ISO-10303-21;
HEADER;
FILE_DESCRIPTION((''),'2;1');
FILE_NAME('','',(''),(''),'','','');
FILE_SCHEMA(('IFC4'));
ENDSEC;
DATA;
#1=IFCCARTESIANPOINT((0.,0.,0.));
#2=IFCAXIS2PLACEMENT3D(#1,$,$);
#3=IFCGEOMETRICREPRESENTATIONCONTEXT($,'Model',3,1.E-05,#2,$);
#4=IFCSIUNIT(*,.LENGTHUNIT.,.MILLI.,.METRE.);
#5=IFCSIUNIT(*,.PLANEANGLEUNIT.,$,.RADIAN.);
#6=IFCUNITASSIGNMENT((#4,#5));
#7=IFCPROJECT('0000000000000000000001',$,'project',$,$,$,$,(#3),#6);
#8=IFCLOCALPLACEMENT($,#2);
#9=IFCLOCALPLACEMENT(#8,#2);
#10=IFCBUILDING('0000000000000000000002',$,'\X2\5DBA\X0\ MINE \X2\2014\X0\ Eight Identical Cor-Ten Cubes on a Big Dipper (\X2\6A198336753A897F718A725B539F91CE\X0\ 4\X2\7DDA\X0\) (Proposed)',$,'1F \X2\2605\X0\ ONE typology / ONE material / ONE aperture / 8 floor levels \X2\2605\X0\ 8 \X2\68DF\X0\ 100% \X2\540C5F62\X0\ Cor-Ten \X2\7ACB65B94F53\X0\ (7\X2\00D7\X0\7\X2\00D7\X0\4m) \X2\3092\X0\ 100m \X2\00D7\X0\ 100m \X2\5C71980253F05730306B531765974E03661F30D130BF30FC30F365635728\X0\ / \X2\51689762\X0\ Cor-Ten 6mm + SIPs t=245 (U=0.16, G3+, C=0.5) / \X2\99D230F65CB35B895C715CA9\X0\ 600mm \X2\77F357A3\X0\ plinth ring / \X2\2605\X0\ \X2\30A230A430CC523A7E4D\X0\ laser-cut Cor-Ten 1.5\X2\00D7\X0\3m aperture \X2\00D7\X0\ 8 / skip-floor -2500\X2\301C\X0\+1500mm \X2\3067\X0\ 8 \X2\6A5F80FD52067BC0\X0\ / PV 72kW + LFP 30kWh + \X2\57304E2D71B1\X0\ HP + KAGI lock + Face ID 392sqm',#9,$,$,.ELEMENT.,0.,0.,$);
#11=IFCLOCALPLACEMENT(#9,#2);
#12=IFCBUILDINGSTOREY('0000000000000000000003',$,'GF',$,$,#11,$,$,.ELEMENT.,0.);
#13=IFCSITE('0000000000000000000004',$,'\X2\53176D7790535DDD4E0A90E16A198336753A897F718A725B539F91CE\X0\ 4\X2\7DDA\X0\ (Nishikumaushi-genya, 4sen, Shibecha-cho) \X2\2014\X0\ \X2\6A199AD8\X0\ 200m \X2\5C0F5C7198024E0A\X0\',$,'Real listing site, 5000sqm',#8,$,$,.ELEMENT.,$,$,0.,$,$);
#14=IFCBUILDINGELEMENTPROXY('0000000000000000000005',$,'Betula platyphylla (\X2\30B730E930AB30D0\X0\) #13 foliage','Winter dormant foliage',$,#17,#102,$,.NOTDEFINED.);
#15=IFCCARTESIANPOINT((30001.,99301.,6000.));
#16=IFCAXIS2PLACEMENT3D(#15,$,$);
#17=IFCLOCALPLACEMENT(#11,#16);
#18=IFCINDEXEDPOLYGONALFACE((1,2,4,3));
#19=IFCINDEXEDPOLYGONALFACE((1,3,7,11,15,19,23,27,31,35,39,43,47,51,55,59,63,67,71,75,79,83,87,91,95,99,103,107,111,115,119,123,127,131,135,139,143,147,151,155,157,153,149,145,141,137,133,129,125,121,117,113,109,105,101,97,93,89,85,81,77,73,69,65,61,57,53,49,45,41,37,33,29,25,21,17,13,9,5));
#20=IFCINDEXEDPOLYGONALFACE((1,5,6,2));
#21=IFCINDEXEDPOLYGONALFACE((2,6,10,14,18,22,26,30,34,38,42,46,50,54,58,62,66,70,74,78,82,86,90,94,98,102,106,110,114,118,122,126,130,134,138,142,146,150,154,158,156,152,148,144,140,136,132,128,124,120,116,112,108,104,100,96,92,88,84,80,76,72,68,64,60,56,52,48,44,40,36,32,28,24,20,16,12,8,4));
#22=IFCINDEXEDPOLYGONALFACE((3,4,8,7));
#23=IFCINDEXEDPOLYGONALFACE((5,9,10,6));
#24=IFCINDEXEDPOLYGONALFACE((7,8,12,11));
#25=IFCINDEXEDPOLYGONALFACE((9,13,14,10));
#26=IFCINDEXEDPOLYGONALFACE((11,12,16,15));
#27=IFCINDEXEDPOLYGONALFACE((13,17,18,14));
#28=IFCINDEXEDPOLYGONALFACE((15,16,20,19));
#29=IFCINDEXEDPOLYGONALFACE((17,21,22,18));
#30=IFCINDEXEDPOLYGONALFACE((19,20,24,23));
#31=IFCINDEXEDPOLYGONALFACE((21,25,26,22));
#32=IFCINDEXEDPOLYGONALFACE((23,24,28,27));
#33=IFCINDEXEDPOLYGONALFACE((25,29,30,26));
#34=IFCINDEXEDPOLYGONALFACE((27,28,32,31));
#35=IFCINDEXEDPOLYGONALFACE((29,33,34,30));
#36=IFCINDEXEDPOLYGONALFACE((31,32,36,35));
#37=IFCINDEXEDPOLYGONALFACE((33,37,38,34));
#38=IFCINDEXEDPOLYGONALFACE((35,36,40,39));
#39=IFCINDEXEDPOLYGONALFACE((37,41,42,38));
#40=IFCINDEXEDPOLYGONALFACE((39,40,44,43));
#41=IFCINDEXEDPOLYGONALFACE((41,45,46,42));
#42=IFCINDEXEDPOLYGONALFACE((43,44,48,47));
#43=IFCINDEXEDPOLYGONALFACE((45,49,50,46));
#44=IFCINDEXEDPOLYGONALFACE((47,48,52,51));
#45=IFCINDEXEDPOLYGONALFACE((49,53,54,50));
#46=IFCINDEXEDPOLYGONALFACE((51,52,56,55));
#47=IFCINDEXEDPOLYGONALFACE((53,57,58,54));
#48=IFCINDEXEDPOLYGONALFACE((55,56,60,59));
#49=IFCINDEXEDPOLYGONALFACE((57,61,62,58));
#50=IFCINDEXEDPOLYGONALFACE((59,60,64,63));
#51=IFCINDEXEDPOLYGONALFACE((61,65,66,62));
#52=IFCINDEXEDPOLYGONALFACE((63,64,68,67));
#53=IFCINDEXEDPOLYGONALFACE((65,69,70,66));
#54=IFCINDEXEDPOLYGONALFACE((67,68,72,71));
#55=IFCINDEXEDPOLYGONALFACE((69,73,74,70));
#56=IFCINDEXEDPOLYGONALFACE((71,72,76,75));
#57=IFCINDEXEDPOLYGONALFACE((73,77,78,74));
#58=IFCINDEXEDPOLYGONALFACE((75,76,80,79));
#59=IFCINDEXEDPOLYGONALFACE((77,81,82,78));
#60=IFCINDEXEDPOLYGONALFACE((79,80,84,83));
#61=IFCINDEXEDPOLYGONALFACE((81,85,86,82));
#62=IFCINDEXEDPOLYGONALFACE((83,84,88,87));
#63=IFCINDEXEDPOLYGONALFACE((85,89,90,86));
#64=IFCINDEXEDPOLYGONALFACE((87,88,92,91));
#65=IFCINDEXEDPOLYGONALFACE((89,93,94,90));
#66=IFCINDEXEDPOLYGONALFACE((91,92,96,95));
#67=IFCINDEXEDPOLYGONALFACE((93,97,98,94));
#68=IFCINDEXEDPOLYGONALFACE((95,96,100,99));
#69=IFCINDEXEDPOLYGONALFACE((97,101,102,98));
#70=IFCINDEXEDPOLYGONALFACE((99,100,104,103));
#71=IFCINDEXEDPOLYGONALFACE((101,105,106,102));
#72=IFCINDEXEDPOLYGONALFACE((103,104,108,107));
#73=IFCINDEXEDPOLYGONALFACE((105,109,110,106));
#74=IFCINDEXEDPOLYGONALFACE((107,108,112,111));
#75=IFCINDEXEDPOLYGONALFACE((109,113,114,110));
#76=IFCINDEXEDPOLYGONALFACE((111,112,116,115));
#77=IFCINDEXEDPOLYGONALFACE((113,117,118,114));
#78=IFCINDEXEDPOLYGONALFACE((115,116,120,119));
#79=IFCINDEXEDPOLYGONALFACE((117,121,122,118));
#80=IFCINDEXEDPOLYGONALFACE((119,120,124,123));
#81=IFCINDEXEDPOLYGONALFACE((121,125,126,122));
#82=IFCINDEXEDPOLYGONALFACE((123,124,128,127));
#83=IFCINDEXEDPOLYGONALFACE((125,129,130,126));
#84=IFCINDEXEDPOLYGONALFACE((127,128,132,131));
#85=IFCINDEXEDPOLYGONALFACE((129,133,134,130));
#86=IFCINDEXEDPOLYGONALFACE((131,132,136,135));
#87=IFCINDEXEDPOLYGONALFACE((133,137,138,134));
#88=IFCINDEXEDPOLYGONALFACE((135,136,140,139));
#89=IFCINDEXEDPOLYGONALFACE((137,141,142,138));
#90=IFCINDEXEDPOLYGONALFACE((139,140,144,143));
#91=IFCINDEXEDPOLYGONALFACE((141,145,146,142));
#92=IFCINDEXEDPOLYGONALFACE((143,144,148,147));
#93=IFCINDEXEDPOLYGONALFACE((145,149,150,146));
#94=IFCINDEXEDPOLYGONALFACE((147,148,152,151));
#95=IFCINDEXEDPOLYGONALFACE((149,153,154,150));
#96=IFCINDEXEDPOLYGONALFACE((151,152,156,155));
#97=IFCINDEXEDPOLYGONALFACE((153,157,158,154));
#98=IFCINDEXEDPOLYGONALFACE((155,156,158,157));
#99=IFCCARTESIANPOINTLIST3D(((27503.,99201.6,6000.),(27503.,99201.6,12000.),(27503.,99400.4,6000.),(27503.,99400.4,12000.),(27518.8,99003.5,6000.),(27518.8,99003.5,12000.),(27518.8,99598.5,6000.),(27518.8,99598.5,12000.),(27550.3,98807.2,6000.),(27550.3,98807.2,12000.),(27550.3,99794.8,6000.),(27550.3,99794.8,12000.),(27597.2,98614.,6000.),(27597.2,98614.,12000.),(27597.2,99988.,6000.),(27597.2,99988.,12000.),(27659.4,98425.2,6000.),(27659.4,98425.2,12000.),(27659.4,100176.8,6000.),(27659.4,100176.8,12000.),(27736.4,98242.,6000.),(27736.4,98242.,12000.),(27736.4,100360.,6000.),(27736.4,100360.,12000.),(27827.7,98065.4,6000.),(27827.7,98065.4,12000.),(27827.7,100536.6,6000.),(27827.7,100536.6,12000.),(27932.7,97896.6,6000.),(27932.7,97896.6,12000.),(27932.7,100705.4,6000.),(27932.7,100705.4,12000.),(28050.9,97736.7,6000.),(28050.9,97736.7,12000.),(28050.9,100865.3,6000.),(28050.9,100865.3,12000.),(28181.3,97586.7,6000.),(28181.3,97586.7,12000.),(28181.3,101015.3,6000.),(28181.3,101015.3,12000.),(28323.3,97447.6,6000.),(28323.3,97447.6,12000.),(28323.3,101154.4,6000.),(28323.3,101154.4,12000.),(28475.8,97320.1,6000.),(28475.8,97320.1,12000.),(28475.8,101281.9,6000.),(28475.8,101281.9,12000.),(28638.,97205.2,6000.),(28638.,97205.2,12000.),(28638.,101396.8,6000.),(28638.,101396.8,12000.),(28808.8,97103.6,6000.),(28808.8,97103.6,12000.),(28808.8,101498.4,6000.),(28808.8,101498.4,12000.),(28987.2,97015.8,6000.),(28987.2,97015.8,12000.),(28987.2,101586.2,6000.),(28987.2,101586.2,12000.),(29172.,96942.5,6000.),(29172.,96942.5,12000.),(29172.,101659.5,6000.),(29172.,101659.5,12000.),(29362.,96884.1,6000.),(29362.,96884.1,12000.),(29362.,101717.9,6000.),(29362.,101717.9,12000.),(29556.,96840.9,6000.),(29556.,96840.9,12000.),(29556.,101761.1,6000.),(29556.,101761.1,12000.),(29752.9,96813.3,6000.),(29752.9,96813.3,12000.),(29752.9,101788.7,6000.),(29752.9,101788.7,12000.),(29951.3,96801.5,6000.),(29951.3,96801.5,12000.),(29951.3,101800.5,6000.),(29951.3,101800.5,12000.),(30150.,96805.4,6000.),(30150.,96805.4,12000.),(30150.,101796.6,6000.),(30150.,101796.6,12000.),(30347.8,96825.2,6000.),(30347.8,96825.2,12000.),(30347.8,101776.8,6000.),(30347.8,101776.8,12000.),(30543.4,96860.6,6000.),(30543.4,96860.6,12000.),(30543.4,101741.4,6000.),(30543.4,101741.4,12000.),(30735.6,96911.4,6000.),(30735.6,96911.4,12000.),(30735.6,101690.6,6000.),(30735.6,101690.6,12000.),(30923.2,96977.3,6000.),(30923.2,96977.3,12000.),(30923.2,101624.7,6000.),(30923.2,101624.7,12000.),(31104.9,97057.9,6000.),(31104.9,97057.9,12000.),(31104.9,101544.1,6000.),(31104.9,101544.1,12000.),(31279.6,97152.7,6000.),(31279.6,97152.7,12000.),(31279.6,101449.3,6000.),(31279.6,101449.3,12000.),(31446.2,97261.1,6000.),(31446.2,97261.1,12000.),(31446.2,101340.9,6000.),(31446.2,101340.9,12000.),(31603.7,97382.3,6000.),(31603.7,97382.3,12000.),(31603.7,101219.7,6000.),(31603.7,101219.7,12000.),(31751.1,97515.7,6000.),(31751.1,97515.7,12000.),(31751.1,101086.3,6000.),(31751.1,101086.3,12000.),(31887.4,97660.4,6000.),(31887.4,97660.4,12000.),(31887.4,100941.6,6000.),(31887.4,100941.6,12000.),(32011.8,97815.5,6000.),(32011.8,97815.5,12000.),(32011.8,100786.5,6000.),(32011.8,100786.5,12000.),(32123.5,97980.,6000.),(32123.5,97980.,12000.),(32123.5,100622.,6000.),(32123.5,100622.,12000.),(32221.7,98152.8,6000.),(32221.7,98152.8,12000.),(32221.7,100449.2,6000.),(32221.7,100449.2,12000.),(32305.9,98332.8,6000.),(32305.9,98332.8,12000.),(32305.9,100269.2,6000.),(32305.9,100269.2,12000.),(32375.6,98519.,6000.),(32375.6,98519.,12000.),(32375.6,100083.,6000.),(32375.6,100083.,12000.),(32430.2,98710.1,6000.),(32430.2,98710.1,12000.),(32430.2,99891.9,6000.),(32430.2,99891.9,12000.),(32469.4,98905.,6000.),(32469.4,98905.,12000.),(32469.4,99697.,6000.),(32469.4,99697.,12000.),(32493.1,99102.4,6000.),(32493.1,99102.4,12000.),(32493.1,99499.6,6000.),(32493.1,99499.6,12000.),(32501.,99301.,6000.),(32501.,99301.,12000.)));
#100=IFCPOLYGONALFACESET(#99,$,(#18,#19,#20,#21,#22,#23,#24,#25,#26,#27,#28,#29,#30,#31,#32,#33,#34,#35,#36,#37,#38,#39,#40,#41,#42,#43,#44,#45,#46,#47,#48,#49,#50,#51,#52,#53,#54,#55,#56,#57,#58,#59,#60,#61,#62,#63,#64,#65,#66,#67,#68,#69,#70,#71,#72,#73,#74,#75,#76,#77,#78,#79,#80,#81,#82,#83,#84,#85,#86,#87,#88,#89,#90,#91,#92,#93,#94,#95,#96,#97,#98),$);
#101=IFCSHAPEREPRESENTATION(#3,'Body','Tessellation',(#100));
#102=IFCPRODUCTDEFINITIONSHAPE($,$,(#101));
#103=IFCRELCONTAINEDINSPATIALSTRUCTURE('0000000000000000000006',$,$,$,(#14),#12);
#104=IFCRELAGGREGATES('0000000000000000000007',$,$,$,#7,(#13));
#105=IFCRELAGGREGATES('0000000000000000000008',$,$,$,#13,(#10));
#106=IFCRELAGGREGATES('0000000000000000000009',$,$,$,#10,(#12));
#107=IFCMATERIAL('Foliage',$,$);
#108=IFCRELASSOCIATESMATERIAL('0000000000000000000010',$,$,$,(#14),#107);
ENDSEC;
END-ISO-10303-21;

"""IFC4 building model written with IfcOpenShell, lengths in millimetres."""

from ifc_helpers import new_model, si_unit, frame, origin, origin_2d, place, context, project, spatial, circle, extrude, material, element, save


model = new_model("IFC4")

# Units and contexts
model_context = context("Model", 3, precision=1e-05, world=origin())
ifc_project = project(units=[si_unit("LENGTHUNIT", "METRE", prefix="MILLI"), si_unit("PLANEANGLEUNIT", "RADIAN")], contexts=[model_context])

# Site, building, storey
site_placement = place(None, origin())
site = spatial("IfcSite", under=ifc_project, at=site_placement, Name="北海道川上郡標茶町西熊牛原野 4線 (Nishikumaushi-genya, 4sen, Shibecha-cho) — 標高 200m 小山頂上", ObjectType="Real listing site, 5000sqm", CompositionType="ELEMENT", RefElevation=0.0)
building_placement = place(site_placement, origin())
building = spatial("IfcBuilding", under=site, at=building_placement, Name="嶺 MINE — Eight Identical Cor-Ten Cubes on a Big Dipper (標茶町西熊牛原野 4線) (Proposed)", ObjectType="1F ★ ONE typology / ONE material / ONE aperture / 8 floor levels ★ 8 棟 100% 同形 Cor-Ten 立方体 (7×7×4m) を 100m × 100m 山頂台地に北斗七星パターン散在 / 全面 Cor-Ten 6mm + SIPs t=245 (U=0.16, G3+, C=0.5) / 駒ヶ岳安山岩 600mm 石垣 plinth ring / ★ アイヌ刺繍 laser-cut Cor-Ten 1.5×3m aperture × 8 / skip-floor -2500〜+1500mm で 8 機能分節 / PV 72kW + LFP 30kWh + 地中熱 HP + KAGI lock + Face ID 392sqm", CompositionType="ELEMENT", ElevationOfRefHeight=0.0, ElevationOfTerrain=0.0)
storey_placement = place(building_placement, origin())
storey = spatial("IfcBuildingStorey", under=building, at=storey_placement, Name="GF", CompositionType="ELEMENT", Elevation=0.0)

# Building element proxy
ifc_material_1 = material(Name="Foliage")
proxy_1_placement = place(storey_placement, frame((30001.0, 99301.0, 6000.0)))
element("IfcBuildingElementProxy", 1, at=proxy_1_placement, inside=storey, material=ifc_material_1, Name="Betula platyphylla (シラカバ) #13 foliage", Description="Winter dormant foliage", PredefinedType="NOTDEFINED", context=model_context, shape_type="SweptSolid", body=[
    extrude(circle(Radius=2500.0, at=origin_2d()), frame((30001.0, 99301.0, 6000.0)), (0.0, 0.0, 1.0), 6000.0),
])

save(model, "model.ifc")
